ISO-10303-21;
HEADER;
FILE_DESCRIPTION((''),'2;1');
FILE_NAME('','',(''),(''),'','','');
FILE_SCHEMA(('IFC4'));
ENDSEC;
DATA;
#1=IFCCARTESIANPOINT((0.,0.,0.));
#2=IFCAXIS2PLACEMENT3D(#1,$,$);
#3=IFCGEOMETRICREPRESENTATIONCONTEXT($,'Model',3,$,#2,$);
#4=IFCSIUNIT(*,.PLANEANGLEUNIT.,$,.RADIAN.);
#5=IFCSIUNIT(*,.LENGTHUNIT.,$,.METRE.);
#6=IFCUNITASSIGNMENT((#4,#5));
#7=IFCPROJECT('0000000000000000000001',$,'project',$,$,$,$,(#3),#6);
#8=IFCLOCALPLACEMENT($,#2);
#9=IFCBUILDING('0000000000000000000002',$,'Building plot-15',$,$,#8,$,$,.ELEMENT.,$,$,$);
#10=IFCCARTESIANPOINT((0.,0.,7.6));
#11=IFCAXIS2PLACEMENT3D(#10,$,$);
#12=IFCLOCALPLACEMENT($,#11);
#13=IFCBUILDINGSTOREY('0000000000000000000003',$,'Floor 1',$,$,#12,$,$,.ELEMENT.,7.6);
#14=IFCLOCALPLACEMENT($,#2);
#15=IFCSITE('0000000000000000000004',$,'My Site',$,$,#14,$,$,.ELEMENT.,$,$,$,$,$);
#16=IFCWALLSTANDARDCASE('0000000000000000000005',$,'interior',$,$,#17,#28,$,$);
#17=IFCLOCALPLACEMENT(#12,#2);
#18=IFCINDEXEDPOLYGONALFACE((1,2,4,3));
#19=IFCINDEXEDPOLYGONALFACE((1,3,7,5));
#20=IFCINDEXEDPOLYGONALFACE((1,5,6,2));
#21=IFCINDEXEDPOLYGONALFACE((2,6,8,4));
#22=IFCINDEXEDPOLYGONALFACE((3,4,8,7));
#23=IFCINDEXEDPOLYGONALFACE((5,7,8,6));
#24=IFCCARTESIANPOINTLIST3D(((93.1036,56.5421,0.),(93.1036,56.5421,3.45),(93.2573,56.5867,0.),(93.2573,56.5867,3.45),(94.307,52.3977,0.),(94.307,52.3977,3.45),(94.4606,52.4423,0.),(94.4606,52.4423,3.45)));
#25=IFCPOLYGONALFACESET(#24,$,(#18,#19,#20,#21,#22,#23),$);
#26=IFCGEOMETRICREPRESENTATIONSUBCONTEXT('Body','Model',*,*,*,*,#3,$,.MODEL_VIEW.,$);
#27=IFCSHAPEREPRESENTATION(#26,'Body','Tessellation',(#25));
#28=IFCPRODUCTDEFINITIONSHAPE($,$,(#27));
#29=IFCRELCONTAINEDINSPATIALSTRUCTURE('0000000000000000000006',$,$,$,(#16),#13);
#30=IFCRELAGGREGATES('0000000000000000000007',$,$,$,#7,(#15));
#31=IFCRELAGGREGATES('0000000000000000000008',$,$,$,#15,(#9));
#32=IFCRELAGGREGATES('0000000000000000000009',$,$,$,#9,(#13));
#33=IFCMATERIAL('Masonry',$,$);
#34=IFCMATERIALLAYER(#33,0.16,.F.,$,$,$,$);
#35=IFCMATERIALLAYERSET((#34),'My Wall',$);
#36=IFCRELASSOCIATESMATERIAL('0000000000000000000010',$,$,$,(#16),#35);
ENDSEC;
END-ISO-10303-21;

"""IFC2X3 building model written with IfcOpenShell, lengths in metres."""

from ifc_helpers import new_model, si_unit, frame, origin, place, context, subcontext, project, spatial, polyline, outline, extrude, material, layer, layer_set, layer_usage, element, save


model = new_model("IFC2X3")

# Units and contexts
model_context = context("Model", 3, world=origin())
body_context = subcontext(model_context, "Body", "Model", "MODEL_VIEW")
ifc_project = project(units=[si_unit("PLANEANGLEUNIT", "RADIAN"), si_unit("LENGTHUNIT", "METRE")], contexts=[model_context])

# Site, building, storey
site_placement = place(None, origin())
site = spatial("IfcSite", under=ifc_project, at=site_placement, Name="My Site", CompositionType="ELEMENT")
building_placement = place(None, origin())
building = spatial("IfcBuilding", under=site, at=building_placement, Name="Building plot-15", CompositionType="ELEMENT")
storey_placement = place(None, frame((0.0, 0.0, 7.6)))
storey = spatial("IfcBuildingStorey", under=building, at=storey_placement, Name="Floor 1", CompositionType="ELEMENT", Elevation=7.6)

# Wall
ifc_material = material(Name="Masonry")
ifc_layer = layer(ifc_material, 0.16, ventilated=False)
ifc_layer_set = layer_set([ifc_layer], Name="My Wall")
ifc_layer_usage = layer_usage(ifc_layer_set, "AXIS2", "NEGATIVE", 0.08)
wall_placement = place(storey_placement, origin())
element("IfcWallStandardCase", 1, at=wall_placement, inside=storey, material=ifc_layer_usage, Name="interior", context=body_context, shape_type="SweptSolid", body=[
    extrude(outline(polyline([(93.2573, 56.5867), (93.1036, 56.5421), (94.307, 52.3977), (94.4606, 52.4423), (93.2573, 56.5867)])), origin(), (0.0, 0.0, 1.0), 3.45),
])

save(model, "model.ifc")
